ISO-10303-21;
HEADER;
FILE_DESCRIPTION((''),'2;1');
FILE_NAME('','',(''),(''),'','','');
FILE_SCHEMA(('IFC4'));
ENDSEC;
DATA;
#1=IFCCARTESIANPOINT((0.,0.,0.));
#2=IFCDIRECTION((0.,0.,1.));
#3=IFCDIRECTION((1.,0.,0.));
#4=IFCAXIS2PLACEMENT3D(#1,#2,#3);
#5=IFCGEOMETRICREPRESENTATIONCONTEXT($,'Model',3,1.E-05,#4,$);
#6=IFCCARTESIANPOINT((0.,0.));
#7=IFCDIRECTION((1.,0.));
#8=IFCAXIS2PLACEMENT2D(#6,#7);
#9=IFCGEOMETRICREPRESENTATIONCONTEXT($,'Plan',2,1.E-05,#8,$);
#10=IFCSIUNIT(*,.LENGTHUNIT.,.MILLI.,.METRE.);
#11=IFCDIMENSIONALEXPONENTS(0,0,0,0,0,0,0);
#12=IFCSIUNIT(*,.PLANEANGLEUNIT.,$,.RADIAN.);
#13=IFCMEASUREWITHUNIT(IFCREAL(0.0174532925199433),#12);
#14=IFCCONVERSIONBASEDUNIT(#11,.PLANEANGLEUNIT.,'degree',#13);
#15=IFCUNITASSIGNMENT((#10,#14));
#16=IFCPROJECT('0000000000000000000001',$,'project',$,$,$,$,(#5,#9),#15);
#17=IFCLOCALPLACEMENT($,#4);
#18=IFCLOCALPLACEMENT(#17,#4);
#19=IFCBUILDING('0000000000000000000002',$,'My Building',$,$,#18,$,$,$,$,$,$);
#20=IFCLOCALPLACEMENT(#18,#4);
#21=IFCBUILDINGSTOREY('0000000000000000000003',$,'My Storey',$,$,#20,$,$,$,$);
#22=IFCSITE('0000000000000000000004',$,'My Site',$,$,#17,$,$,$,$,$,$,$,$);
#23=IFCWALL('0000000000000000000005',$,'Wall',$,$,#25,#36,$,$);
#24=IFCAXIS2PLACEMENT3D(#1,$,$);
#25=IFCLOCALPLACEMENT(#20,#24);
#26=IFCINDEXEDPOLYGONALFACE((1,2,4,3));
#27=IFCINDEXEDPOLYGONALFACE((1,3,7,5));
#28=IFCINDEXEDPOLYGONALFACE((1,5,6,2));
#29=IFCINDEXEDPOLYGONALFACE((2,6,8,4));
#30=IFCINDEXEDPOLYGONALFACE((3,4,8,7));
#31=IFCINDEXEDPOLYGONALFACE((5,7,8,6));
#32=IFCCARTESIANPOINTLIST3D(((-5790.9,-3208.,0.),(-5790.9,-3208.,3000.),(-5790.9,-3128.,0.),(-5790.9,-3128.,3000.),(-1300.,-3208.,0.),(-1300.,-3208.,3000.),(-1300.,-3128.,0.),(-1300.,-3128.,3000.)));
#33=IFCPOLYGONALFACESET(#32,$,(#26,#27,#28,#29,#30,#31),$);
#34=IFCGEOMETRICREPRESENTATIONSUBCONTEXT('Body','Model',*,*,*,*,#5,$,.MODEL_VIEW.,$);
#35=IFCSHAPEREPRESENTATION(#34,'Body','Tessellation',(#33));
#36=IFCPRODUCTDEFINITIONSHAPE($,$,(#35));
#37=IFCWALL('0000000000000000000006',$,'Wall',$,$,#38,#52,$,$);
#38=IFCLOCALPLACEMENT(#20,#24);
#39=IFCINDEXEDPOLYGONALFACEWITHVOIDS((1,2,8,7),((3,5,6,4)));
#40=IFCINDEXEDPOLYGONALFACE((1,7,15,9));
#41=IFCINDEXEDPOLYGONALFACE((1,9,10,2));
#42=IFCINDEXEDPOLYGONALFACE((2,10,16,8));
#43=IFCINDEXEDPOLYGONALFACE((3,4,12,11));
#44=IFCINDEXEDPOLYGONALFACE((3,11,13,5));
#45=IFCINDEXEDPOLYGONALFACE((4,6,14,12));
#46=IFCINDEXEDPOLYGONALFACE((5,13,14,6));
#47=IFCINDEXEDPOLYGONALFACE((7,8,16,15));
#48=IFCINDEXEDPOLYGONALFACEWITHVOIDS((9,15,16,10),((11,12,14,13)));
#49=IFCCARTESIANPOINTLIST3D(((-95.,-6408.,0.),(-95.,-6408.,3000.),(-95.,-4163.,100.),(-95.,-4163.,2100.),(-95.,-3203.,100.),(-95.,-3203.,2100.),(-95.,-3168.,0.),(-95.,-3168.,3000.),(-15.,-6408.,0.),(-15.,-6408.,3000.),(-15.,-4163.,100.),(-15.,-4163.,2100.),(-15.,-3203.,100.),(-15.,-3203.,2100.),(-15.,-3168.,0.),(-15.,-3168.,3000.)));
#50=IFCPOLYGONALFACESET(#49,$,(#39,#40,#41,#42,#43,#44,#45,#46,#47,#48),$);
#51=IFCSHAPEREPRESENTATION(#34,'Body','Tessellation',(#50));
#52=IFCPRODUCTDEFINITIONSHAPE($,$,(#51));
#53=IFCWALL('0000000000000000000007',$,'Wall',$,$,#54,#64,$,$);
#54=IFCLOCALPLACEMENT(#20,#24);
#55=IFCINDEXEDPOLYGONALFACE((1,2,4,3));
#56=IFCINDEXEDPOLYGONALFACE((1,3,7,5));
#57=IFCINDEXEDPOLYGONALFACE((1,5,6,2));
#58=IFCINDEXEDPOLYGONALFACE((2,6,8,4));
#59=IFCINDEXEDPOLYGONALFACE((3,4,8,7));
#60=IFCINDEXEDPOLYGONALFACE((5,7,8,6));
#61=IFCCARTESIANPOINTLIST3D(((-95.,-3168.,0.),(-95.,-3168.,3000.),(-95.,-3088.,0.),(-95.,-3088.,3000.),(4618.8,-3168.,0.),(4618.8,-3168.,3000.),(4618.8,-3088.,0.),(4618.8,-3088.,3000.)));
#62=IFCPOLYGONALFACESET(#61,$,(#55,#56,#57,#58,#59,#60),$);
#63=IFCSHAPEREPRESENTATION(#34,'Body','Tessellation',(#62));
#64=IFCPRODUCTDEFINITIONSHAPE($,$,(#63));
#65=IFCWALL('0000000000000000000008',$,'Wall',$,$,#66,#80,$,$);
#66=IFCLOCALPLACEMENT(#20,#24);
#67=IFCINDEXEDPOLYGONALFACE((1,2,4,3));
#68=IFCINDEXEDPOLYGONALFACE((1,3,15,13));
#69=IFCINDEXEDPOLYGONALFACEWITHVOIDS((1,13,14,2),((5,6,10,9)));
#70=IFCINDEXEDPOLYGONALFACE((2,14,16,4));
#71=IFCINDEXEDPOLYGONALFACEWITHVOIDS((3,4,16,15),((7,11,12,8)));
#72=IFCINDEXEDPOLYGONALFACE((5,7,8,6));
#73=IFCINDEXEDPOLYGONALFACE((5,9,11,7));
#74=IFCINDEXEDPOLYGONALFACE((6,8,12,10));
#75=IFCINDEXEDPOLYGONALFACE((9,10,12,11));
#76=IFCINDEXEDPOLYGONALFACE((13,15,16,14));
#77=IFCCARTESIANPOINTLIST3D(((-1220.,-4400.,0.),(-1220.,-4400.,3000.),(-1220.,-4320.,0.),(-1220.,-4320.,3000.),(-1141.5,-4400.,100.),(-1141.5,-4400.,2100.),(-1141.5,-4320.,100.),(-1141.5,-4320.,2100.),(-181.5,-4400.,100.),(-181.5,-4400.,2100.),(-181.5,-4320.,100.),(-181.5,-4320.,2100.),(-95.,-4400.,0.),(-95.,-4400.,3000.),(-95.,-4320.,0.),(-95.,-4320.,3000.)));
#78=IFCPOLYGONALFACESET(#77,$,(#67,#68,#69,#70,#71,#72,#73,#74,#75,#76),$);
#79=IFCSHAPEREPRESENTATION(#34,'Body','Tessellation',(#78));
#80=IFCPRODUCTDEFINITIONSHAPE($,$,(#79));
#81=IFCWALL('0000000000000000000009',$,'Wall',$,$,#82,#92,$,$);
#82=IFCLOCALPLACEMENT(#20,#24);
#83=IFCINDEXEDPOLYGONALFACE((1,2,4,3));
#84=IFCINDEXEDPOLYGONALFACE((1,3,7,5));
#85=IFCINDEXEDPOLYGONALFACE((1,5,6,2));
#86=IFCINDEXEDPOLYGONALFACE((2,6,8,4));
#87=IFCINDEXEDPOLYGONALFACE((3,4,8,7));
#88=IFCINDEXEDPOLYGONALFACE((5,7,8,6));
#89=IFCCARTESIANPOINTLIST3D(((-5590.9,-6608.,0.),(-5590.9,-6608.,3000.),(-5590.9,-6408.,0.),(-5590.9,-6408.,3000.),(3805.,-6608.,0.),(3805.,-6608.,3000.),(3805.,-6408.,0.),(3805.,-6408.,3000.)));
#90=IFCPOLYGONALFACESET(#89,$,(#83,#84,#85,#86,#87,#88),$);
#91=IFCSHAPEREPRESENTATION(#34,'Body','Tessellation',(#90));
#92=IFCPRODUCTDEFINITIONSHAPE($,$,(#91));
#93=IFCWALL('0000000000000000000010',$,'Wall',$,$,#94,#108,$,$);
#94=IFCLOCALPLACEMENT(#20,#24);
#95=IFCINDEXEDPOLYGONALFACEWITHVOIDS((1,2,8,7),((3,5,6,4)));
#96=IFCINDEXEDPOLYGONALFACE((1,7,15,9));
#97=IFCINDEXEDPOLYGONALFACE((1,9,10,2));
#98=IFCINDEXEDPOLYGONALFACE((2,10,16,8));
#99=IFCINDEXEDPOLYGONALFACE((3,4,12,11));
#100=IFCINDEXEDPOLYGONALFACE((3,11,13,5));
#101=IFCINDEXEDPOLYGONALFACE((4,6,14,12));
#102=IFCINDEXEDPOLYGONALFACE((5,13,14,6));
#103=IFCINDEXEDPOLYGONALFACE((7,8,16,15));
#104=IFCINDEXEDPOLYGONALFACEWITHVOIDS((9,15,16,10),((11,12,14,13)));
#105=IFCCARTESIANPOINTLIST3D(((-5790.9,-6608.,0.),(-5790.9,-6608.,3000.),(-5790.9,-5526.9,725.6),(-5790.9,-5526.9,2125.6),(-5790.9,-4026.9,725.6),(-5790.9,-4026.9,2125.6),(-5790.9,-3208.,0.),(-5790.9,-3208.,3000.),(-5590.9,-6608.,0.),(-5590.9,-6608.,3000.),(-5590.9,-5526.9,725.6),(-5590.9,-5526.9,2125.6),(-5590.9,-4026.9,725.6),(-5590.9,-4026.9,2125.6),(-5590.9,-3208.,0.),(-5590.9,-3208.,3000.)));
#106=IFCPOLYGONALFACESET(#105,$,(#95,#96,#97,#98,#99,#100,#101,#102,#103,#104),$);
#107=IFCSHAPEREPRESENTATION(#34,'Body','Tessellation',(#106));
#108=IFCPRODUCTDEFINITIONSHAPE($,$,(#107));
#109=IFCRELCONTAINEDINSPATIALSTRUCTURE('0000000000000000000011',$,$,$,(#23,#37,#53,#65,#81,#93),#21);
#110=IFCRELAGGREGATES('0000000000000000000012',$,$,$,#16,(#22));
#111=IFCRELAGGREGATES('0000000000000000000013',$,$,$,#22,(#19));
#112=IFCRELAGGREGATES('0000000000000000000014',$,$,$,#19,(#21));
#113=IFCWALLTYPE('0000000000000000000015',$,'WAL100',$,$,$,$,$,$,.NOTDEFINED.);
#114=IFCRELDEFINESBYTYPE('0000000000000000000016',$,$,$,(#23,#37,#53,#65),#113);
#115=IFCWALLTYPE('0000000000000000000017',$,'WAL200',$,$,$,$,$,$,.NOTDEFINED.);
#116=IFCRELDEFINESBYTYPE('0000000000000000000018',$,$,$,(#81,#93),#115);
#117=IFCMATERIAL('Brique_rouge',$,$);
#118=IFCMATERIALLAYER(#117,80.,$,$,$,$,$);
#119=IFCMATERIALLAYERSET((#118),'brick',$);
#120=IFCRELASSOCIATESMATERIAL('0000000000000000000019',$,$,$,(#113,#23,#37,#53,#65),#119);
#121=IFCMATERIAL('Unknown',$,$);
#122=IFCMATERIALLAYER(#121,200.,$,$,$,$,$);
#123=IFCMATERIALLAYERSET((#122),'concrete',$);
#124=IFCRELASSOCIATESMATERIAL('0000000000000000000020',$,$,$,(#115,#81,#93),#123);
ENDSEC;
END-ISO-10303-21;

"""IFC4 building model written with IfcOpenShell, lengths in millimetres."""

from ifc_helpers import new_model, entity, si_unit, converted_unit, frame, origin_with_axes, origin_2d_with_axis, place, context, subcontext, project, spatial, line, indexed_curve, outline, extrude, source, transform, mapped, material, layer, layer_set, layer_usage, type_object, element, save


model = new_model("IFC4")

# Units and contexts
model_context = context("Model", 3, precision=1e-05, world=origin_with_axes())
plan_context = context("Plan", 2, precision=1e-05, world=origin_2d_with_axis())
body_context_1 = subcontext(model_context, "Body", "Model", "MODEL_VIEW")
ifc_project = project(units=[si_unit("LENGTHUNIT", "METRE", prefix="MILLI"), converted_unit("PLANEANGLEUNIT", "degree", entity("IfcReal", 0.0174532925199433), si_unit("PLANEANGLEUNIT", "RADIAN"), dimensions=[0, 0, 0, 0, 0, 0, 0])], contexts=[model_context, plan_context])

# Site, building, storey
site_placement = place(None, origin_with_axes())
site = spatial("IfcSite", under=ifc_project, at=site_placement, Name="My Site")
building_placement = place(site_placement, origin_with_axes())
building = spatial("IfcBuilding", under=site, at=building_placement, Name="My Building")
storey_placement = place(building_placement, origin_with_axes())
storey = spatial("IfcBuildingStorey", under=building, at=storey_placement, Name="My Storey")

# Wall
ifc_material_1 = material(Name="Brique_rouge")
ifc_layer_1 = layer(ifc_material_1, 80.0)
ifc_layer_set_1 = layer_set([ifc_layer_1], Name="brick")
ifc_layer_usage_1 = layer_usage(ifc_layer_set_1, "AXIS2", "POSITIVE", 0.0)
wall_type_1 = type_object("IfcWallType", Name="WAL100", PredefinedType="NOTDEFINED", material=ifc_layer_set_1)
wall_1_placement = place(storey_placement, frame((-1300.0, -3128.0, 0.0), z_axis=(0.0, 0.0, 1.0), x_axis=(-1.0, 0.000001, 0.0)))
element("IfcWall", 1, at=wall_1_placement, inside=storey, type_object=wall_type_1, material=ifc_layer_usage_1, Name="Wall", context=body_context_1, shape_type="SweptSolid", body=[
    extrude(outline(indexed_curve([(0.0, 0.0), (0.0, 80.0), (4490.9, 80.0), (4490.9, 0.0), (0.0, 0.0)], self_intersect=False)), origin_with_axes(), (0.0, 0.0, 1.0), 3000.0),
])

# Wall, opening
ifc_layer_usage_2 = layer_usage(ifc_layer_set_1, "AXIS2", "POSITIVE", 0.0)
wall_2_placement = place(storey_placement, frame((-95.0, -3168.0, 0.0), z_axis=(0.0, 0.0, 1.0), x_axis=(-0.000001, -1.0, 0.0)))
wall_2 = element("IfcWall", 2, at=wall_2_placement, inside=storey, type_object=wall_type_1, material=ifc_layer_usage_2, Name="Wall", context=body_context_1, shape_type="SweptSolid", body=[
    extrude(outline(indexed_curve([(0.0, 0.0), (0.0, 80.0), (3240.0, 80.0), (3240.0, 0.0), (0.0, 0.0)], self_intersect=False)), origin_with_axes(), (0.0, 0.0, 1.0), 3000.0),
])
shared_shape_1 = source(origin_with_axes(), body_context_1, "Body", "SweptSolid", [
    extrude(outline(indexed_curve([(0.0, 0.0), (960.0, 0.0), (960.0, 2000.0), (0.0, 2000.0)], segments=[line(1, 2, 3, 4, 1)])), frame((0.0, -100.0, 0.0), z_axis=(0.0, -1.0, 0.0), x_axis=(1.0, 0.0, 0.0)), (0.0, 0.0, -1.0), 280.0),
])
opening_1_placement = place(wall_2_placement, frame((35.0, -2.5, 100.0), z_axis=(0.0, 0.0, 1.0), x_axis=(1.0, 0.0, 0.0)))
element("IfcOpeningElement", 3, at=opening_1_placement, cuts=wall_2, PredefinedType="OPENING", context=body_context_1, shape_type="MappedRepresentation", body=[
    mapped(shared_shape_1, transform((0.0, 0.0, 0.0), x_axis=(1.0, 0.0, 0.0), y_axis=(0.0, 1.0, 0.0), z_axis=(0.0, 0.0, 1.0), scale=1.0)),
])

# Wall
ifc_layer_usage_3 = layer_usage(ifc_layer_set_1, "AXIS2", "POSITIVE", 0.0)
wall_3_placement = place(storey_placement, frame((-95.0, -3168.0, 0.0), z_axis=(0.0, 0.0, 1.0), x_axis=(1.0, -0.000001, 0.0)))
element("IfcWall", 4, at=wall_3_placement, inside=storey, type_object=wall_type_1, material=ifc_layer_usage_3, Name="Wall", context=body_context_1, shape_type="SweptSolid", body=[
    extrude(outline(indexed_curve([(0.0, 0.0), (0.0, 80.0), (4713.8, 80.0), (4713.8, 0.0), (0.0, 0.0)], self_intersect=False)), origin_with_axes(), (0.0, 0.0, 1.0), 3000.0),
])

# Wall, opening
ifc_layer_usage_4 = layer_usage(ifc_layer_set_1, "AXIS2", "POSITIVE", 0.0)
wall_4_placement = place(storey_placement, frame((-1220.0, -4400.0, 0.0), z_axis=(0.0, 0.0, 1.0), x_axis=(1.0, -0.000001, 0.0)))
wall_4 = element("IfcWall", 5, at=wall_4_placement, inside=storey, type_object=wall_type_1, material=ifc_layer_usage_4, Name="Wall", context=body_context_1, shape_type="SweptSolid", body=[
    extrude(outline(indexed_curve([(0.0, 0.0), (0.0, 80.0), (1125.0, 80.0), (1125.0, 0.0), (0.0, 0.0)], self_intersect=False)), origin_with_axes(), (0.0, 0.0, 1.0), 3000.0),
])
shared_shape_2 = source(origin_with_axes(), body_context_1, "Body", "SweptSolid", [
    extrude(outline(indexed_curve([(0.0, 0.0), (960.0, 0.0), (960.0, 2000.0), (0.0, 2000.0)], segments=[line(1, 2, 3, 4, 1)])), frame((0.0, -100.0, 0.0), z_axis=(0.0, -1.0, 0.0), x_axis=(1.0, 0.0, 0.0)), (0.0, 0.0, -1.0), 280.0),
])
opening_2_placement = place(wall_4_placement, frame((78.5, -2.5, 100.0), z_axis=(0.0, 0.0, 1.0), x_axis=(1.0, 0.0, 0.0)))
element("IfcOpeningElement", 6, at=opening_2_placement, cuts=wall_4, PredefinedType="OPENING", context=body_context_1, shape_type="MappedRepresentation", body=[
    mapped(shared_shape_2, transform((0.0, 0.0, 0.0), x_axis=(1.0, 0.0, 0.0), y_axis=(0.0, 1.0, 0.0), z_axis=(0.0, 0.0, 1.0), scale=1.0)),
])

# Wall
ifc_material_2 = material(Name="Unknown")
ifc_layer_2 = layer(ifc_material_2, 200.0)
ifc_layer_set_2 = layer_set([ifc_layer_2], Name="concrete")
ifc_layer_usage_5 = layer_usage(ifc_layer_set_2, "AXIS2", "POSITIVE", 0.0)
wall_type_2 = type_object("IfcWallType", Name="WAL200", PredefinedType="NOTDEFINED", material=ifc_layer_set_2)
wall_5_placement = place(storey_placement, frame((-5590.9, -6608.0, 0.0), z_axis=(0.0, 0.0, 1.0), x_axis=(1.0, -0.000001, 0.0)))
element("IfcWall", 7, at=wall_5_placement, inside=storey, type_object=wall_type_2, material=ifc_layer_usage_5, Name="Wall", context=body_context_1, shape_type="SweptSolid", body=[
    extrude(outline(indexed_curve([(0.0, 0.0), (0.0, 200.0), (9395.9, 200.0), (9395.9, 0.0), (0.0, 0.0)], self_intersect=False)), origin_with_axes(), (0.0, 0.0, 1.0), 3000.0),
])

# Wall, opening
ifc_layer_usage_6 = layer_usage(ifc_layer_set_2, "AXIS2", "POSITIVE", 0.0)
wall_6_placement = place(storey_placement, frame((-5590.9, -6608.0, 0.0), z_axis=(0.0, 0.0, 1.0), x_axis=(0.000002, 1.0, 0.0)))
wall_6 = element("IfcWall", 8, at=wall_6_placement, inside=storey, type_object=wall_type_2, material=ifc_layer_usage_6, Name="Wall", context=body_context_1, shape_type="SweptSolid", body=[
    extrude(outline(indexed_curve([(0.0, 0.0), (0.0, 200.0), (3400.0, 200.0), (3400.0, 0.0), (0.0, 0.0)], self_intersect=False)), origin_with_axes(), (0.0, 0.0, 1.0), 3000.0),
])
shared_shape_3 = source(origin_with_axes(), body_context_1, "Body", "SweptSolid", [
    extrude(outline(indexed_curve([(0.0, 0.0), (1500.0, 0.0), (1500.0, 1400.0), (0.0, 1400.0)], segments=[line(1, 2, 3, 4, 1)])), frame((0.0, -100.0, 0.0), z_axis=(0.0, -1.0, 0.0), x_axis=(1.0, 0.0, 0.0)), (0.0, 0.0, -1.0), 400.0),
])
opening_3_placement = place(wall_6_placement, frame((1081.1, 0.0, 725.6), z_axis=(0.0, 0.0, 1.0), x_axis=(1.0, 0.0, 0.0)))
element("IfcOpeningElement", 9, at=opening_3_placement, cuts=wall_6, PredefinedType="OPENING", context=body_context_1, shape_type="MappedRepresentation", body=[
    mapped(shared_shape_3, transform((0.0, 0.0, 0.0), x_axis=(1.0, 0.0, 0.0), y_axis=(0.0, 1.0, 0.0), z_axis=(0.0, 0.0, 1.0), scale=1.0)),
])

save(model, "model.ifc")
